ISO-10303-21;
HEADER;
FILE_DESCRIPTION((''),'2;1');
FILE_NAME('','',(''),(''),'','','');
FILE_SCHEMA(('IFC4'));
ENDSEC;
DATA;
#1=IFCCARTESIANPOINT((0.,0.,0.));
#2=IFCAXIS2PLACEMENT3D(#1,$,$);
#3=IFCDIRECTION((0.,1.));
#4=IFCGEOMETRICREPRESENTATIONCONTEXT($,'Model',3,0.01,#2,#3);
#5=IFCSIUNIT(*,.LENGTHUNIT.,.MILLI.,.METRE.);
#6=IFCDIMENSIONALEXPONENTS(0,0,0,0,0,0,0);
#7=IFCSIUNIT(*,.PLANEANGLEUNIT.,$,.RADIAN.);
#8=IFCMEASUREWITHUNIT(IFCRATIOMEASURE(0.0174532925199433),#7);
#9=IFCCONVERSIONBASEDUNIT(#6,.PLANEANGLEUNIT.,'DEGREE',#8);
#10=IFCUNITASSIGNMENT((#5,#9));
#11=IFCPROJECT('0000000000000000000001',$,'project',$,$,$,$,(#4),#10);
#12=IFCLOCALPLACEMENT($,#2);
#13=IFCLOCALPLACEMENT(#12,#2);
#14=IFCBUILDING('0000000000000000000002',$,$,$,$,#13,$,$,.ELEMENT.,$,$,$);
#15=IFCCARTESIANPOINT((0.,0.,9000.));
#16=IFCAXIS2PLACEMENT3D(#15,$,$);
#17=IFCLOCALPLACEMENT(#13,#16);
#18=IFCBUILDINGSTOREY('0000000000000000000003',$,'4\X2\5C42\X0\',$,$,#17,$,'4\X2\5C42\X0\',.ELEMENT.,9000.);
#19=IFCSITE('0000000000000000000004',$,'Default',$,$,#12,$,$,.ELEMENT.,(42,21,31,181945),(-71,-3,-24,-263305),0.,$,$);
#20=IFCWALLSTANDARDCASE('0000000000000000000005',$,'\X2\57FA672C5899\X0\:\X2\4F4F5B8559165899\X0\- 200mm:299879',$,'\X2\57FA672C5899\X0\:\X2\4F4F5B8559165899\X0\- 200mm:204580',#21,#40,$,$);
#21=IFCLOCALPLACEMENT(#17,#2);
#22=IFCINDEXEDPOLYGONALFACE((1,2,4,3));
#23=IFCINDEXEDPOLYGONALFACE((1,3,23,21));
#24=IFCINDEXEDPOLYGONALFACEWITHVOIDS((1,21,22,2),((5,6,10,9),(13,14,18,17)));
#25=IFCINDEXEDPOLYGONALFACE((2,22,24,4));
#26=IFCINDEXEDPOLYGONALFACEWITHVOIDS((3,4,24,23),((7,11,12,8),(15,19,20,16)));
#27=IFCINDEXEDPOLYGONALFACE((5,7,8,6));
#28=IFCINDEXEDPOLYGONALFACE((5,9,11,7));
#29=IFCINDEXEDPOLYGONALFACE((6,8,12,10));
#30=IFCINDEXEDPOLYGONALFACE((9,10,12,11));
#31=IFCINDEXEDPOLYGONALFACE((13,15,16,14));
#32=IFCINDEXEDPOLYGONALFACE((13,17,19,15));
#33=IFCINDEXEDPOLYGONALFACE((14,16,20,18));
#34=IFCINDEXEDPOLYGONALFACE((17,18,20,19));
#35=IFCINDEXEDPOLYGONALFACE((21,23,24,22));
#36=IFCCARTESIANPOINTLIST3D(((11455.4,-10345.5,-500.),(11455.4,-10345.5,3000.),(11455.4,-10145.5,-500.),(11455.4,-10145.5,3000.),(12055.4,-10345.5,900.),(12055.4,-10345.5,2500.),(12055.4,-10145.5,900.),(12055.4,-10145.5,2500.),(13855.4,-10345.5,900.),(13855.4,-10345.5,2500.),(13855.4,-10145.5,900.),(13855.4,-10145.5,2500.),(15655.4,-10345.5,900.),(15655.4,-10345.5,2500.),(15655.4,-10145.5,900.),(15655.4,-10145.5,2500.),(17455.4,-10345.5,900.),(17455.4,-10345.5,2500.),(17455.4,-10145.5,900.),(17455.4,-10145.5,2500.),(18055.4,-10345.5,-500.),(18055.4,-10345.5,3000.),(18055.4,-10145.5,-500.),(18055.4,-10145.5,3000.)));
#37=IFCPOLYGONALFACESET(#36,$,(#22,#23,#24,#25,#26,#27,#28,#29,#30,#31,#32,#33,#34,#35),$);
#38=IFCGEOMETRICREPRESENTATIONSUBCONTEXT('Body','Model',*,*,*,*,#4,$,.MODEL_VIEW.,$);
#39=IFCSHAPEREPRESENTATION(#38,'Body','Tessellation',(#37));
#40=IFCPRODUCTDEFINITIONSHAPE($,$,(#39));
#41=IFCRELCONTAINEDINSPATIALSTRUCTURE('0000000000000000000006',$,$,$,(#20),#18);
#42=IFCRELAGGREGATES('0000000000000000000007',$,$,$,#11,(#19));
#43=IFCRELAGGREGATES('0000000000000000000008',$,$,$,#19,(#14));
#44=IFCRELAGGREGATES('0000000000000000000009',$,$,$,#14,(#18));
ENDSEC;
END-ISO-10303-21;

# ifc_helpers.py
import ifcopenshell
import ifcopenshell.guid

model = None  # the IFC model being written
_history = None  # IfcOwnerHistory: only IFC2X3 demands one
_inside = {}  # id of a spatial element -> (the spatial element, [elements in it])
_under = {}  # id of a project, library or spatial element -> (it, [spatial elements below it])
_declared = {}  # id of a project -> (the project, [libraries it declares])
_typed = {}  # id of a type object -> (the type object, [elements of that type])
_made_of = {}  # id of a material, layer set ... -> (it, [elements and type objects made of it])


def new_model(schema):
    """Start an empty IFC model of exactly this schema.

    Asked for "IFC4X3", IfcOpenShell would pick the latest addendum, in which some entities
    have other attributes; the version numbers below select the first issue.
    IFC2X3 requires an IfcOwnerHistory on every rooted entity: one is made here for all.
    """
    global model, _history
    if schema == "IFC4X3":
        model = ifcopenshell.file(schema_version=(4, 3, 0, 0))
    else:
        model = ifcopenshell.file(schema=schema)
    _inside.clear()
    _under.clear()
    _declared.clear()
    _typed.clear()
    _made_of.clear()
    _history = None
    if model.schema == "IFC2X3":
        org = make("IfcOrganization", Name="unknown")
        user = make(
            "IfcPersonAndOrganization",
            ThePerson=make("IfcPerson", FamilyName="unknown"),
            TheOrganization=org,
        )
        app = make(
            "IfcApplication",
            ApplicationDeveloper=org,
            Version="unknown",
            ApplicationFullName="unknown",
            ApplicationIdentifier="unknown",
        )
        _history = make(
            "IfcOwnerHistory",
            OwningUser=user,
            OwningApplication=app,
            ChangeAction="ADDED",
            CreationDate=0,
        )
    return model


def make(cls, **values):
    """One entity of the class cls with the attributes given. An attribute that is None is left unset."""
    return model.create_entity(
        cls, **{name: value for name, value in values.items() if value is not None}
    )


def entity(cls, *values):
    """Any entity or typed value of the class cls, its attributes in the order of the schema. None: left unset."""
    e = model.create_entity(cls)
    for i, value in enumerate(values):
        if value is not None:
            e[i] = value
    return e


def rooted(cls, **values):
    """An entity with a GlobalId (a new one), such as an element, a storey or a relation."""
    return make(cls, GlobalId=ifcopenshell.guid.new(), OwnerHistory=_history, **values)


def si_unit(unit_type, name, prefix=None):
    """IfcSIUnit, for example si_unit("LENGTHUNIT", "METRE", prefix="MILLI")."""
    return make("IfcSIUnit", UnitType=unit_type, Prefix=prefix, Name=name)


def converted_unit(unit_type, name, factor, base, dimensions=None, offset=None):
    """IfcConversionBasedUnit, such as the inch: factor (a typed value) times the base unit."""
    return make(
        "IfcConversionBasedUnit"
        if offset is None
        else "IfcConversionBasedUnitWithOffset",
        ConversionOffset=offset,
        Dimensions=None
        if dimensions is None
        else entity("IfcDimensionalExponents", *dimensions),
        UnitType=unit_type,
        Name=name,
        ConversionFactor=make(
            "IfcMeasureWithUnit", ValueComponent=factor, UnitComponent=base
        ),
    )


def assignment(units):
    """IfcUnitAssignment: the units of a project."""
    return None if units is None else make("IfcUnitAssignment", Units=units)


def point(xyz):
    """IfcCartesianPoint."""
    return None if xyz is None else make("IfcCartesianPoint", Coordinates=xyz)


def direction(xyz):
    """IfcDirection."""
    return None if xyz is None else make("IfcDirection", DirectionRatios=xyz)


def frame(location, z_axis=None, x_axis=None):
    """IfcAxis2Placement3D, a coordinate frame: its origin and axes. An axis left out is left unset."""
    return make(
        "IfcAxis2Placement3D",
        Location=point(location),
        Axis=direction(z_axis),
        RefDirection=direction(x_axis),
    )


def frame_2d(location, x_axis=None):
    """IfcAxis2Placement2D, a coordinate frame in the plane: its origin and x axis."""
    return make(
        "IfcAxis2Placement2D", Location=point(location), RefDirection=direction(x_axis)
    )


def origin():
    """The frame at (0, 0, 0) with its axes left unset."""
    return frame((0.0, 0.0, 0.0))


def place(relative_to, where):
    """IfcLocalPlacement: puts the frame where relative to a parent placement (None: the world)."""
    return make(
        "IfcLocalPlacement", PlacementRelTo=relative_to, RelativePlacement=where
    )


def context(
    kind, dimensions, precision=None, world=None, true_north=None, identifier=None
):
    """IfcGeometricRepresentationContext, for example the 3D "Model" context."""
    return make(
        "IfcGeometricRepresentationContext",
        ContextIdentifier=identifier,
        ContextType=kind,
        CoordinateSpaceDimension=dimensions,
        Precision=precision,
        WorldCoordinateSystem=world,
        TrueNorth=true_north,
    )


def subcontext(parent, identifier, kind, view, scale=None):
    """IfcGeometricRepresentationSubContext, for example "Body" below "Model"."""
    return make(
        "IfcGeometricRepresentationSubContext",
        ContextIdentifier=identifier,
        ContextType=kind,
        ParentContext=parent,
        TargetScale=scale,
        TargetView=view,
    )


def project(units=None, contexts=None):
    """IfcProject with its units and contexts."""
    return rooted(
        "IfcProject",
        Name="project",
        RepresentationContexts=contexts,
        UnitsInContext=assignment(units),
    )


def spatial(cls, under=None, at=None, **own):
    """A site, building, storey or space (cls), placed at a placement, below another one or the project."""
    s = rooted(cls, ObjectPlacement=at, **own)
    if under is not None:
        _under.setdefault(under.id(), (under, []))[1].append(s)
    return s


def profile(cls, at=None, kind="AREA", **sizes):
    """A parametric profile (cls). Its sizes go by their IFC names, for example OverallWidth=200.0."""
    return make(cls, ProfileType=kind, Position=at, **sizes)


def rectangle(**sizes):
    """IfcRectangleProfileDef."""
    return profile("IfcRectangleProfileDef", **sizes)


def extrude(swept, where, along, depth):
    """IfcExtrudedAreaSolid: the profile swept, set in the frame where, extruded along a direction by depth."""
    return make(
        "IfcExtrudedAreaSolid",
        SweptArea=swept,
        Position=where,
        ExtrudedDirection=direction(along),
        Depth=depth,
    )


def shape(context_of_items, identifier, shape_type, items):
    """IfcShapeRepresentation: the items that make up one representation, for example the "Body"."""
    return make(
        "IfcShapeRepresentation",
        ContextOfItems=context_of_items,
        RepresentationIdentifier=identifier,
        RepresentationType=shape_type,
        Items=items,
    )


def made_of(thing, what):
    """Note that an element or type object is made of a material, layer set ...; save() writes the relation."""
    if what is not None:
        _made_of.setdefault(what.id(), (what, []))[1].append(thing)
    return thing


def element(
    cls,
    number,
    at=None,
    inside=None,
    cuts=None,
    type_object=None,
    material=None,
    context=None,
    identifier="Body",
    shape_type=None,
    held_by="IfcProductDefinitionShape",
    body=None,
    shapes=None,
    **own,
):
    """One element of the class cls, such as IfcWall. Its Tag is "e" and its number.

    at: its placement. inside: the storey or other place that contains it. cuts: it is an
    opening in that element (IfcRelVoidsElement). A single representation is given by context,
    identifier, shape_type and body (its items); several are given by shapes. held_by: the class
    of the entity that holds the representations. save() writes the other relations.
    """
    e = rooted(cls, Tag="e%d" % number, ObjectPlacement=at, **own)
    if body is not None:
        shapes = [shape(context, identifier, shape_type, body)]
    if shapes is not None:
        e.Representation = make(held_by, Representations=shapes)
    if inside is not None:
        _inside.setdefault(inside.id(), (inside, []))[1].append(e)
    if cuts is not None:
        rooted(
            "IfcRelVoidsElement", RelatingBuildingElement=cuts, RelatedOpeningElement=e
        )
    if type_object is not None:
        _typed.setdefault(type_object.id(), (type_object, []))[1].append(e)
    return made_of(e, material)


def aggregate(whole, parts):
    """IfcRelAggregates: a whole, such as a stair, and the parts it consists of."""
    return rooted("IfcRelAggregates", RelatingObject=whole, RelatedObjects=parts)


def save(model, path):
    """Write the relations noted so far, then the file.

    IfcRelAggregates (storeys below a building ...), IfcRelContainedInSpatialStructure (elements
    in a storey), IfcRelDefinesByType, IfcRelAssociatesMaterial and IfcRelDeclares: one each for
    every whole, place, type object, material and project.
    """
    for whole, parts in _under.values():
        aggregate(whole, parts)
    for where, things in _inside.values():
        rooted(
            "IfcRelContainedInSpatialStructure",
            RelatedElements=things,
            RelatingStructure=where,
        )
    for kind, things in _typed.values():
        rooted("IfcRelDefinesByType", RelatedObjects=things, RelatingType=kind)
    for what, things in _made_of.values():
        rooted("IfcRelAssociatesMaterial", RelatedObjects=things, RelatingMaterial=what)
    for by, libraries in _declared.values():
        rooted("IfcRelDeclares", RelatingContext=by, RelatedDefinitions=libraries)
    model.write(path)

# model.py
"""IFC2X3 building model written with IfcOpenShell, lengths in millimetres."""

from ifc_helpers import new_model, entity, si_unit, converted_unit, direction, frame, frame_2d, origin, place, context, subcontext, project, spatial, rectangle, extrude, element, save


model = new_model("IFC2X3")

# Units and contexts
model_context = context("Model", 3, precision=0.01, world=origin(), true_north=direction((0.0, 1.0)))
body_context = subcontext(model_context, "Body", "Model", "MODEL_VIEW")
ifc_project = project(units=[si_unit("LENGTHUNIT", "METRE", prefix="MILLI"), converted_unit("PLANEANGLEUNIT", "DEGREE", entity("IfcRatioMeasure", 0.0174532925199433), si_unit("PLANEANGLEUNIT", "RADIAN"), dimensions=[0, 0, 0, 0, 0, 0, 0])], contexts=[model_context])

# Site, building, storey
site_placement = place(None, origin())
site = spatial("IfcSite", under=ifc_project, at=site_placement, Name="Default", CompositionType="ELEMENT", RefLatitude=(42, 21, 31, 181945), RefLongitude=(-71, -3, -24, -263305), RefElevation=0.0)
building_placement = place(site_placement, origin())
building = spatial("IfcBuilding", under=site, at=building_placement, CompositionType="ELEMENT")
storey_placement = place(building_placement, frame((0.0, 0.0, 9000.0)))
storey = spatial("IfcBuildingStorey", under=building, at=storey_placement, Name="4层", LongName="4层", CompositionType="ELEMENT", Elevation=9000.0)

# Wall, openings
wall_placement = place(storey_placement, frame((11455.4, -10245.5, -500.0)))
wall = element("IfcWallStandardCase", 1, at=wall_placement, inside=storey, Name="基本墙:住宅外墙- 200mm:299879", ObjectType="基本墙:住宅外墙- 200mm:204580", context=body_context, shape_type="SweptSolid", body=[
    extrude(rectangle(XDim=6600.0, YDim=200.0, at=frame_2d((3300.0, 0.0), x_axis=(-1.0, 0.0))), origin(), (0.0, 0.0, 1.0), 3500.0),
])
opening_1_placement = place(wall_placement, frame((600.0, -100.0, 1400.0)))
element("IfcOpeningElement", 2, at=opening_1_placement, cuts=wall, ObjectType="Opening", context=body_context, shape_type="SweptSolid", body=[
    extrude(rectangle(XDim=1600.0, YDim=1800.0, at=frame_2d((800.0, 900.0), x_axis=(1.0, 0.0))), frame((0.0, 0.0, 0.0), z_axis=(0.0, 1.0, 0.0), x_axis=(0.0, 0.0, 1.0)), (0.0, 0.0, 1.0), 200.0),
])
opening_2_placement = place(wall_placement, frame((4200.0, -100.0, 1400.0)))
element("IfcOpeningElement", 3, at=opening_2_placement, cuts=wall, ObjectType="Opening", context=body_context, shape_type="SweptSolid", body=[
    extrude(rectangle(XDim=1600.0, YDim=1800.0, at=frame_2d((800.0, 900.0), x_axis=(1.0, 0.0))), frame((0.0, 0.0, 0.0), z_axis=(0.0, 1.0, 0.0), x_axis=(0.0, 0.0, 1.0)), (0.0, 0.0, 1.0), 200.0),
])

save(model, "model.ifc")
